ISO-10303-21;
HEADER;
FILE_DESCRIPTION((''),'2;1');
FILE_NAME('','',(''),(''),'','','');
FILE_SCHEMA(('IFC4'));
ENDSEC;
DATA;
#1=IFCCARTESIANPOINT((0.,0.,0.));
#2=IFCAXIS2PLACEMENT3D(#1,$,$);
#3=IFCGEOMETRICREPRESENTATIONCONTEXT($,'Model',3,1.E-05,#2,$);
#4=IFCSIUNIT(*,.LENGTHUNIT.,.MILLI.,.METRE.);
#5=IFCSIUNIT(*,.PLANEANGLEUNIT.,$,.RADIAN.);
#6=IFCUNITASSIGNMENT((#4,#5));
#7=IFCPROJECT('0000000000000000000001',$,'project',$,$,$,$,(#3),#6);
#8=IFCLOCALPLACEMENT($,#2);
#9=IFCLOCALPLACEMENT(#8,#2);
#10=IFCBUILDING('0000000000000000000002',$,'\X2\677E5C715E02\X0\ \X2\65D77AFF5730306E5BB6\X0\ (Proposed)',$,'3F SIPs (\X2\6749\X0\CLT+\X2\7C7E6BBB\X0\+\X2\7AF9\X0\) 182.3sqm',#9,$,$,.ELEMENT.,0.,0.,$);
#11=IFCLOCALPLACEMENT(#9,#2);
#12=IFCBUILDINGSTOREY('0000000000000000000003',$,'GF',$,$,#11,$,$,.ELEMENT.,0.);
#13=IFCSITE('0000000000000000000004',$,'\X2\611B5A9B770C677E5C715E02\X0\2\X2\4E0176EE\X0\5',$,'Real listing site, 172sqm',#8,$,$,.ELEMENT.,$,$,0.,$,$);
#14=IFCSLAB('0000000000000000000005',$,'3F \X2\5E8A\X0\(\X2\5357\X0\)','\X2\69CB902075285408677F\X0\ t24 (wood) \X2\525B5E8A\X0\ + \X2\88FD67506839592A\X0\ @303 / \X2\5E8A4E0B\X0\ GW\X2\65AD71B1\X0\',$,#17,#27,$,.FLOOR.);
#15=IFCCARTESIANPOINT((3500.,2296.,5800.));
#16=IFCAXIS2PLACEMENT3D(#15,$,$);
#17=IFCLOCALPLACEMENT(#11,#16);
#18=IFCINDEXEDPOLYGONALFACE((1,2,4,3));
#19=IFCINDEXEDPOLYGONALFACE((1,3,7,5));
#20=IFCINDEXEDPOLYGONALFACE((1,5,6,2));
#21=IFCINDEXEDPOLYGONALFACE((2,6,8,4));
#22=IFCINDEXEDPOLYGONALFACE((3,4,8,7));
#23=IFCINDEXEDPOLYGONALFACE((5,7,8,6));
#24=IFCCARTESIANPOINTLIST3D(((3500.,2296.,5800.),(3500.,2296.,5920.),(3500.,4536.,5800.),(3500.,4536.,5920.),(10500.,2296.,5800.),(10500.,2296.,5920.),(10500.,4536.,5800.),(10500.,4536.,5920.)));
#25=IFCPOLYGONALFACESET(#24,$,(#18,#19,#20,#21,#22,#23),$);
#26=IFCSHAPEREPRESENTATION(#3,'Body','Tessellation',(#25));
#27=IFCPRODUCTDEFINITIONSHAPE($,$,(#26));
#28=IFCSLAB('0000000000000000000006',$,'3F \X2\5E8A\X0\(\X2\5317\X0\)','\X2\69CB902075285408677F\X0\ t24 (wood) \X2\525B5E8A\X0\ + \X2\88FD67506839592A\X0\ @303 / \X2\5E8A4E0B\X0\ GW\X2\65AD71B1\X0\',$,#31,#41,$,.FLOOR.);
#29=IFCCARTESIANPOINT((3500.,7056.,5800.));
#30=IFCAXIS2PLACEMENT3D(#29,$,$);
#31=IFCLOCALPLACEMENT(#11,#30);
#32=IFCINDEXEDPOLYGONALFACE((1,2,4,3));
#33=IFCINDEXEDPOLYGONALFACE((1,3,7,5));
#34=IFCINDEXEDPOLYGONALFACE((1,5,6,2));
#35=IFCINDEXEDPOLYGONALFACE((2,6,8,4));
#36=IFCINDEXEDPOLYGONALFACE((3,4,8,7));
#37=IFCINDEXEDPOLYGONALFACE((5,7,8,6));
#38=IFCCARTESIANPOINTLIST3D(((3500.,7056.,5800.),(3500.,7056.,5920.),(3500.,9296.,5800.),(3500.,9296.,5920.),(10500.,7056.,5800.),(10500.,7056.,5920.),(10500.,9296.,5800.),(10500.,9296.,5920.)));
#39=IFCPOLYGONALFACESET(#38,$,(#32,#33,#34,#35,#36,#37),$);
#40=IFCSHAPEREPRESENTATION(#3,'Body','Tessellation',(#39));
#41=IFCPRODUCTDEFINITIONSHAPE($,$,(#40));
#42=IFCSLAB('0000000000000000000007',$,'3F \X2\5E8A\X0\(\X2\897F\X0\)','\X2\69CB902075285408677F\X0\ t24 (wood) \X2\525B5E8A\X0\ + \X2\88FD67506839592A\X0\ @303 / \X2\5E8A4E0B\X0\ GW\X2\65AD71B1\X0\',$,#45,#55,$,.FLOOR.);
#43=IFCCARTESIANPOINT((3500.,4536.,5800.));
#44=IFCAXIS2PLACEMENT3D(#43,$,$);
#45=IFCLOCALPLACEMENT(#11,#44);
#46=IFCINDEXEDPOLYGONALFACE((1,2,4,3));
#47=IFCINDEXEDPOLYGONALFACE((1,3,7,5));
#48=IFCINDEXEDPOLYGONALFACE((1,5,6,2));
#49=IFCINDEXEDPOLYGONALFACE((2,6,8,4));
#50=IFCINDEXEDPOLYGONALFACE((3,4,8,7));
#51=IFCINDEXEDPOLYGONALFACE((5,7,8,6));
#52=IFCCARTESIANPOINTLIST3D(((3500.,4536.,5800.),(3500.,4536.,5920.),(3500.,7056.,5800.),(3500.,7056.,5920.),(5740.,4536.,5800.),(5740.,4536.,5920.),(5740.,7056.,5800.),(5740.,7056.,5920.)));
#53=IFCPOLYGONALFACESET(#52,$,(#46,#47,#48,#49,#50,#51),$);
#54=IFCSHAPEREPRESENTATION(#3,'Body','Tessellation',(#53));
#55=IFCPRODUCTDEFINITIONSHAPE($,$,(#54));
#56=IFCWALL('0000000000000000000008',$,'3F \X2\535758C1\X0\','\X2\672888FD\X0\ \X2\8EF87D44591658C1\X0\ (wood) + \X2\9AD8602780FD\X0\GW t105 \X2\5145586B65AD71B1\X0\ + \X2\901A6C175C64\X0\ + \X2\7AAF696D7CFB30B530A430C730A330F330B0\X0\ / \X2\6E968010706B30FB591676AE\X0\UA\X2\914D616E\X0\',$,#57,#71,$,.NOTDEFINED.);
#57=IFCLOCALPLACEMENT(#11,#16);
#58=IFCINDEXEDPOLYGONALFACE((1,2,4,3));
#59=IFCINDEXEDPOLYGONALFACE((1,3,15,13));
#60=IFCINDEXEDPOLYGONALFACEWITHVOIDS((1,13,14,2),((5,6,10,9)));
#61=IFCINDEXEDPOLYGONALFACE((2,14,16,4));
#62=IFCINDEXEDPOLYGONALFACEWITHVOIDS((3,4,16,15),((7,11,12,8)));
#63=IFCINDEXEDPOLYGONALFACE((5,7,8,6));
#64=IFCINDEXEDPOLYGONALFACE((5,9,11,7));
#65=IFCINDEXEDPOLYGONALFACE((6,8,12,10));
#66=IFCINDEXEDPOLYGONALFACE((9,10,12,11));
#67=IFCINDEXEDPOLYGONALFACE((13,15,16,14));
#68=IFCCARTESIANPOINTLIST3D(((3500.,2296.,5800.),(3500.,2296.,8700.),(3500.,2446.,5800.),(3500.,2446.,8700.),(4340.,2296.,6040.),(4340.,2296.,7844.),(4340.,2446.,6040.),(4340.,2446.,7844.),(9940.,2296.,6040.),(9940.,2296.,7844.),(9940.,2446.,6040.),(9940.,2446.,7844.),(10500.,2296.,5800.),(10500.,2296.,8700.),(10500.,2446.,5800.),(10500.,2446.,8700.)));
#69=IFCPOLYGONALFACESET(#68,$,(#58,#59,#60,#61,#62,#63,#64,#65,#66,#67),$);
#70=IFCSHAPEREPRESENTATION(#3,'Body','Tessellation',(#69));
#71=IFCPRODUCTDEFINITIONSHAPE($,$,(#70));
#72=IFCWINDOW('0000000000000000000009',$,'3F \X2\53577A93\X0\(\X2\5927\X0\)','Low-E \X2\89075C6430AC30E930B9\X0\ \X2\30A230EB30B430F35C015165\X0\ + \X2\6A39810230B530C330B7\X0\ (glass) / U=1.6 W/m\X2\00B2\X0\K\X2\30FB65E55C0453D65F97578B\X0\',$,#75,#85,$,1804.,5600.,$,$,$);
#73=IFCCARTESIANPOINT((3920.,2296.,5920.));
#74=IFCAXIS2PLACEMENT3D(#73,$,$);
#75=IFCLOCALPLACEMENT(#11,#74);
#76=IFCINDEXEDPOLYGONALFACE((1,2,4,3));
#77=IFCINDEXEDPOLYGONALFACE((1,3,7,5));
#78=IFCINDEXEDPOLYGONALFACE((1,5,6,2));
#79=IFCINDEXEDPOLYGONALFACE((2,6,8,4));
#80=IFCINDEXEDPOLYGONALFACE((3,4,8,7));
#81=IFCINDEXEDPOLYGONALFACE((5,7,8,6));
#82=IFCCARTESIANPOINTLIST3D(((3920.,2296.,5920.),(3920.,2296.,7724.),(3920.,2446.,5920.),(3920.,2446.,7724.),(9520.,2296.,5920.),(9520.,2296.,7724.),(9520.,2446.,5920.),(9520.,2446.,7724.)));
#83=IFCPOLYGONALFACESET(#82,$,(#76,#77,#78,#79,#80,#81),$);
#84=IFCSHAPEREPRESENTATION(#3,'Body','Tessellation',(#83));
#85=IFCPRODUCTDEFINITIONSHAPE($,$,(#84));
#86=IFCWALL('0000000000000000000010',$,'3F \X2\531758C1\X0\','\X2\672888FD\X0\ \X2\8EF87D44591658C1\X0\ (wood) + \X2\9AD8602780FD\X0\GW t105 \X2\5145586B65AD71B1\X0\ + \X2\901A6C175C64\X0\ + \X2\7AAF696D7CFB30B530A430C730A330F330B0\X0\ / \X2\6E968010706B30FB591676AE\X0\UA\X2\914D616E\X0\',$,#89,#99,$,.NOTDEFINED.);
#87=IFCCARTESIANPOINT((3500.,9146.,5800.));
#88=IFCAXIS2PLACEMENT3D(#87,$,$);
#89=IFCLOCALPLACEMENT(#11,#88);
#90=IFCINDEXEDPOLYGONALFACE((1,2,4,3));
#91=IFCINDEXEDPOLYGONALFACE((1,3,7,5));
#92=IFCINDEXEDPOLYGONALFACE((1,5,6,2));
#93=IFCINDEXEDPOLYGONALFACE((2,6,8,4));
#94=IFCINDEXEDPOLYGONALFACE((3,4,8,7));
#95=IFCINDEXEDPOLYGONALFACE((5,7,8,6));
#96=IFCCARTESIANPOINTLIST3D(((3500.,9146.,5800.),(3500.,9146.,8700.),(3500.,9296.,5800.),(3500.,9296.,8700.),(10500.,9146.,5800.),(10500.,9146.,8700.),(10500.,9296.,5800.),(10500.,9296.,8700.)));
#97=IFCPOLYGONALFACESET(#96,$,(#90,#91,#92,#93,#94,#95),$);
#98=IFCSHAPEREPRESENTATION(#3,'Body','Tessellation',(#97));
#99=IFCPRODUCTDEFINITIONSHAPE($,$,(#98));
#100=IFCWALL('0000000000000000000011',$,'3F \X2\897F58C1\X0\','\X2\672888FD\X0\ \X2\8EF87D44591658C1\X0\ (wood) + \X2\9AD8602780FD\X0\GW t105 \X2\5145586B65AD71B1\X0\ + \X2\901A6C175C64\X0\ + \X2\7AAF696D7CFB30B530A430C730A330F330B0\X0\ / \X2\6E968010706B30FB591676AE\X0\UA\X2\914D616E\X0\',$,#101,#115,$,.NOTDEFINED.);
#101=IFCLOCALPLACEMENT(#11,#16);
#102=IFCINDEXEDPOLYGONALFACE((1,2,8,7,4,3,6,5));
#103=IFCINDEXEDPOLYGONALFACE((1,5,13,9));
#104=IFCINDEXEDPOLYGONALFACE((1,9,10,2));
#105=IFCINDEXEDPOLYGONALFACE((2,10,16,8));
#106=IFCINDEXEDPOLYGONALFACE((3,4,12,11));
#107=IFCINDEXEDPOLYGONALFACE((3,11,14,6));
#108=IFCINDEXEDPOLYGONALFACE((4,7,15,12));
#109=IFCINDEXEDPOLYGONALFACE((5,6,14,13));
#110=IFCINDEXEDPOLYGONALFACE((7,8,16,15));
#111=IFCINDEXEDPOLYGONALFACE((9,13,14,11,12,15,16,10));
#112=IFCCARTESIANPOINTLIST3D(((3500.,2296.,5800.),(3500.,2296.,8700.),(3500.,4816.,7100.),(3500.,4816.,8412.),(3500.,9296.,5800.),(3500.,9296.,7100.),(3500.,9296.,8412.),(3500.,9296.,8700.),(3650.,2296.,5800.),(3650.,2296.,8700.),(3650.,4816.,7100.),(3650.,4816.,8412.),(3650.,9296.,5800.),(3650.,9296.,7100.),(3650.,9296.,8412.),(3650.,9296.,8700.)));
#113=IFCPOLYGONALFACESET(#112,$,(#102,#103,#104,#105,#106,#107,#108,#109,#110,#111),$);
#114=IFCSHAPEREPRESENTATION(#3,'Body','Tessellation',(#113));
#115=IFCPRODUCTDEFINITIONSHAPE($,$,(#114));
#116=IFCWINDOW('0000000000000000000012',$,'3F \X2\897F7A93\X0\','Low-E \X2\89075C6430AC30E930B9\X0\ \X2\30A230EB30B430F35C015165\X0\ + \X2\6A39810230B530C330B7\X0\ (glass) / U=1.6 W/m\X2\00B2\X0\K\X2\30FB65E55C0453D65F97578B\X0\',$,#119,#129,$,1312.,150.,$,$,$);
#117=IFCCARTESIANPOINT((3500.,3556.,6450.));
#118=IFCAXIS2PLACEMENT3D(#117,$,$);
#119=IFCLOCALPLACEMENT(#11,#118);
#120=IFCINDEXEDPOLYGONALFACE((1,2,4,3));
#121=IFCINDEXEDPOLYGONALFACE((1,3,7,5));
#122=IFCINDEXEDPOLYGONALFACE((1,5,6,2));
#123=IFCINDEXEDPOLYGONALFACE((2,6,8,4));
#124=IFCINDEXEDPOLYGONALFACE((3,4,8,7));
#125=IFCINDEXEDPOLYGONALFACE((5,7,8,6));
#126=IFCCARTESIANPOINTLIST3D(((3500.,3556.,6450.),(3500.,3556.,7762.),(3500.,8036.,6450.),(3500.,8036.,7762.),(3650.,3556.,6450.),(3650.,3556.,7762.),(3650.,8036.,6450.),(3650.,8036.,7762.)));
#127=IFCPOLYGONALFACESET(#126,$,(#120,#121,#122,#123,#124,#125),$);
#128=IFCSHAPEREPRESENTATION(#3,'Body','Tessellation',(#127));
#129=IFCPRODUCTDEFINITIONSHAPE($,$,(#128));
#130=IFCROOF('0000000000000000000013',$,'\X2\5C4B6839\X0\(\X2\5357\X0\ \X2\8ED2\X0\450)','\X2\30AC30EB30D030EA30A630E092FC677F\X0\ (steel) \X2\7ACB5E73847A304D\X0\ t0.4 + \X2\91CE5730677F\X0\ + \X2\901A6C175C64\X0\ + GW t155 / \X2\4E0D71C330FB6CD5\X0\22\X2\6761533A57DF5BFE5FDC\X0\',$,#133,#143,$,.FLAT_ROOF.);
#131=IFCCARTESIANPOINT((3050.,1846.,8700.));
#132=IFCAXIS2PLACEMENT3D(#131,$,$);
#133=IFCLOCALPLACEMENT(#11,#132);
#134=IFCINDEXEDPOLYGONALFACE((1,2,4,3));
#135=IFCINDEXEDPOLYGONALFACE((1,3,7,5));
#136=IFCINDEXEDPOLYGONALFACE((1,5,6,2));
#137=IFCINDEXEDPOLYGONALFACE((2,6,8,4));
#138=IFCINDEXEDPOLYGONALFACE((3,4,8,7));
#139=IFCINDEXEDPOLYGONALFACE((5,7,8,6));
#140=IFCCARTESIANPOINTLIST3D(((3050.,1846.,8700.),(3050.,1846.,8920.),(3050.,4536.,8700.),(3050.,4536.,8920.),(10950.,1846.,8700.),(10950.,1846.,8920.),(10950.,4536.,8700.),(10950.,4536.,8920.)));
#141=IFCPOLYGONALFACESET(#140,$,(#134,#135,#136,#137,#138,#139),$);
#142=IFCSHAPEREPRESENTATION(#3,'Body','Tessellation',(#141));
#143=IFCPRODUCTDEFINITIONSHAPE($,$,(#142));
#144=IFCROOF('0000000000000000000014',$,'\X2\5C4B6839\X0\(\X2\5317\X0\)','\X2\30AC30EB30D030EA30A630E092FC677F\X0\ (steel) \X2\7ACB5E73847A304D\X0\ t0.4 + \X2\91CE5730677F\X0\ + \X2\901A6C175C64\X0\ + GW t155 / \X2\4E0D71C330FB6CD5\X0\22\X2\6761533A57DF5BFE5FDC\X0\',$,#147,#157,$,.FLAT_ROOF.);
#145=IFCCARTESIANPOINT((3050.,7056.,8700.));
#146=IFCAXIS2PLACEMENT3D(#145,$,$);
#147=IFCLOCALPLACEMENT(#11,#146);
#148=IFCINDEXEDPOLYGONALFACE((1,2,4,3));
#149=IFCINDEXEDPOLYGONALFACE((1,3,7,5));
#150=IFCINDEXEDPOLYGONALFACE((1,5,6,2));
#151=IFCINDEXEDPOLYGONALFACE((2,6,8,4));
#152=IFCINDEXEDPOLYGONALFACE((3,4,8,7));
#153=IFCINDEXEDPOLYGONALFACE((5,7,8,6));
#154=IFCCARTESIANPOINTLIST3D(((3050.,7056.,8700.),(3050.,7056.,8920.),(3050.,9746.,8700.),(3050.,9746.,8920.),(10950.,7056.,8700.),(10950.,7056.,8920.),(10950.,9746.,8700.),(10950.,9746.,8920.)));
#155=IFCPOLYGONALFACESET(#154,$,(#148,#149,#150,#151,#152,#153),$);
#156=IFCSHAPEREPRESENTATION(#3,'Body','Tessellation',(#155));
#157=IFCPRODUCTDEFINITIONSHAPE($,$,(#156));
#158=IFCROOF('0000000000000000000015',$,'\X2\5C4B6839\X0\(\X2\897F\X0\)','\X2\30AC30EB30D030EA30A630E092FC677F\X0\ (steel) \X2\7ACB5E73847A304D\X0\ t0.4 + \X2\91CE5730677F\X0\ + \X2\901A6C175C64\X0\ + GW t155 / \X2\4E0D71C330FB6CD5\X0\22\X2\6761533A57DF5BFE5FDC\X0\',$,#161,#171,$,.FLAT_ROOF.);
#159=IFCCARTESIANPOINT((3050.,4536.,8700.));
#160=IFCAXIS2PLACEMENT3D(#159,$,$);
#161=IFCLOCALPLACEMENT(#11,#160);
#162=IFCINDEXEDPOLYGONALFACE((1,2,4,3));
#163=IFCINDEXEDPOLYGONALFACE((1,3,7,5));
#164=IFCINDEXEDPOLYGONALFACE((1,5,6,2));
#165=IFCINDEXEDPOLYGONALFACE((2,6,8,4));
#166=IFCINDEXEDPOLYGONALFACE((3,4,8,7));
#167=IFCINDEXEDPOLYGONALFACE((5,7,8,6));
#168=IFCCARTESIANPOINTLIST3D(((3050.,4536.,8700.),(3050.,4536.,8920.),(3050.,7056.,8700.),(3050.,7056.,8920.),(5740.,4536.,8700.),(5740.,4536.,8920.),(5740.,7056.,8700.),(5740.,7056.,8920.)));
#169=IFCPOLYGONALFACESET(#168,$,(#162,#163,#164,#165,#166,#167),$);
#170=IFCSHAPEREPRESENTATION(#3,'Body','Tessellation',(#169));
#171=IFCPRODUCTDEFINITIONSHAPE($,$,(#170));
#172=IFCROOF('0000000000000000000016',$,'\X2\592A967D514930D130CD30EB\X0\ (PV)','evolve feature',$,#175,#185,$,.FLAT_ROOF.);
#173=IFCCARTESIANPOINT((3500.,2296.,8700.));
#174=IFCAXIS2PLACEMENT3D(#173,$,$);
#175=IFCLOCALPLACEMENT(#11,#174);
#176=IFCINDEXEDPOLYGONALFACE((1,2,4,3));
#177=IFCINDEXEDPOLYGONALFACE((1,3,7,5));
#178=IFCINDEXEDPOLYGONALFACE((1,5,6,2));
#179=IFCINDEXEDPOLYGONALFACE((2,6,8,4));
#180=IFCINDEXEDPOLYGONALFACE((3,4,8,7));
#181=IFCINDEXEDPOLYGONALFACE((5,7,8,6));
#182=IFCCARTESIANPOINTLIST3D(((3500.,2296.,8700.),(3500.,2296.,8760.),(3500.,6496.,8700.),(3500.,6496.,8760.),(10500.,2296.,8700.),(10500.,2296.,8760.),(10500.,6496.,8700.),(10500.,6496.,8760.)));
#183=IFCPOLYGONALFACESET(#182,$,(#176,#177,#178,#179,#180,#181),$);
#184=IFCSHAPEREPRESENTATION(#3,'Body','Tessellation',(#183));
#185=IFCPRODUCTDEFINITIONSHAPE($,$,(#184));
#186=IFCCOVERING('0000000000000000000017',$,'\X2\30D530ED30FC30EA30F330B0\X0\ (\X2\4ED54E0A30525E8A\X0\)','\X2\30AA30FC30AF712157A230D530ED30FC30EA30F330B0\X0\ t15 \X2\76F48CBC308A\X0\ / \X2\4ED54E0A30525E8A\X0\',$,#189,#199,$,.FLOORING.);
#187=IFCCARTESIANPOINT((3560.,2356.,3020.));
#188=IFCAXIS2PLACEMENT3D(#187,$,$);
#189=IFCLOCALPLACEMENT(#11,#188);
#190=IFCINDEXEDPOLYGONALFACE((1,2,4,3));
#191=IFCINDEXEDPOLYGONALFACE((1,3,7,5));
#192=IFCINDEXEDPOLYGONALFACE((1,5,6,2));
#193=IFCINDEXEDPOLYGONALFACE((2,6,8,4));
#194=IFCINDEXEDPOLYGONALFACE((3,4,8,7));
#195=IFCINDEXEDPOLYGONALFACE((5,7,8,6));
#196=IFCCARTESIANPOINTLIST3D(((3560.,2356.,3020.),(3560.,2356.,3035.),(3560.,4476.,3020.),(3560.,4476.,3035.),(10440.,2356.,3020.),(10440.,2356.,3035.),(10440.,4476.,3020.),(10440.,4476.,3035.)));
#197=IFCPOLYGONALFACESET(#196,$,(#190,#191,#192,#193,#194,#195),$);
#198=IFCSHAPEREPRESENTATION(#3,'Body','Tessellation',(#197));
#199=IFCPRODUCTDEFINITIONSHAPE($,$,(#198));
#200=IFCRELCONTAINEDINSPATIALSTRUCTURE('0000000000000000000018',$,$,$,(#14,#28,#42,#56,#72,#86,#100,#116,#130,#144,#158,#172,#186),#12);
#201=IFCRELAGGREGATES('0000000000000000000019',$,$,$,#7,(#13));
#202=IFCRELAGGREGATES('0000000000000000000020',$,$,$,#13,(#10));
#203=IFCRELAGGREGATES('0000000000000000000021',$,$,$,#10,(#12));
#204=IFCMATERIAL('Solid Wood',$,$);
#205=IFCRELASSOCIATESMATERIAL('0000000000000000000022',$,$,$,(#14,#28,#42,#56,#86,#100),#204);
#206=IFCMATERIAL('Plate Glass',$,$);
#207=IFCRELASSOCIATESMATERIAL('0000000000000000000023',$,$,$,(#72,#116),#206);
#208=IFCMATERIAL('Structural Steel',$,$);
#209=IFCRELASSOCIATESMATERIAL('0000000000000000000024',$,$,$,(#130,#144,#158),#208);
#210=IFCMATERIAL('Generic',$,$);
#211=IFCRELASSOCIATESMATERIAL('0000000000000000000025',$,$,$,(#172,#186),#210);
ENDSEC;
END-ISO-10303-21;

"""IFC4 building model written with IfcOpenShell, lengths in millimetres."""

from ifc_helpers import new_model, si_unit, frame, frame_2d, origin, place, context, project, spatial, rectangle, extrude, material, element, fill, save


model = new_model("IFC4")

# Units and contexts
model_context = context("Model", 3, precision=1e-05, world=origin())
ifc_project = project(units=[si_unit("LENGTHUNIT", "METRE", prefix="MILLI"), si_unit("PLANEANGLEUNIT", "RADIAN")], contexts=[model_context])

# Site, building, storey
site_placement = place(None, origin())
site = spatial("IfcSite", under=ifc_project, at=site_placement, Name="愛媛県松山市2丁目5", ObjectType="Real listing site, 172sqm", CompositionType="ELEMENT", RefElevation=0.0)
building_placement = place(site_placement, origin())
building = spatial("IfcBuilding", under=site, at=building_placement, Name="松山市 旗竿地の家 (Proposed)", ObjectType="3F SIPs (杉CLT+籾殻+竹) 182.3sqm", CompositionType="ELEMENT", ElevationOfRefHeight=0.0, ElevationOfTerrain=0.0)
storey_placement = place(building_placement, origin())
storey = spatial("IfcBuildingStorey", under=building, at=storey_placement, Name="GF", CompositionType="ELEMENT", Elevation=0.0)

# Slabs
ifc_material_1 = material(Name="Solid Wood")
slab_1_placement = place(storey_placement, frame((3500.0, 2296.0, 5800.0)))
element("IfcSlab", 1, at=slab_1_placement, inside=storey, material=ifc_material_1, Name="3F 床(南)", Description="構造用合板 t24 (wood) 剛床 + 製材根太 @303 / 床下 GW断熱", PredefinedType="FLOOR", context=model_context, shape_type="SweptSolid", body=[
    extrude(rectangle(XDim=7000.0, YDim=2240.0, at=frame_2d((3500.0, 1120.0))), frame((3500.0, 2296.0, 5800.0)), (0.0, 0.0, 1.0), 120.0),
])
slab_2_placement = place(storey_placement, frame((3500.0, 7056.0, 5800.0)))
element("IfcSlab", 2, at=slab_2_placement, inside=storey, material=ifc_material_1, Name="3F 床(北)", Description="構造用合板 t24 (wood) 剛床 + 製材根太 @303 / 床下 GW断熱", PredefinedType="FLOOR", context=model_context, shape_type="SweptSolid", body=[
    extrude(rectangle(XDim=7000.0, YDim=2240.0, at=frame_2d((3500.0, 1120.0))), frame((3500.0, 7056.0, 5800.0)), (0.0, 0.0, 1.0), 120.0),
])
slab_3_placement = place(storey_placement, frame((3500.0, 4536.0, 5800.0)))
element("IfcSlab", 3, at=slab_3_placement, inside=storey, material=ifc_material_1, Name="3F 床(西)", Description="構造用合板 t24 (wood) 剛床 + 製材根太 @303 / 床下 GW断熱", PredefinedType="FLOOR", context=model_context, shape_type="SweptSolid", body=[
    extrude(rectangle(XDim=2240.0, YDim=2520.0, at=frame_2d((1120.0, 1260.0))), frame((3500.0, 4536.0, 5800.0)), (0.0, 0.0, 1.0), 120.0),
])

# Wall, opening, window
wall_1_placement = place(storey_placement, frame((3500.0, 2296.0, 5800.0)))
wall_1 = element("IfcWall", 4, at=wall_1_placement, inside=storey, material=ifc_material_1, Name="3F 南壁", Description="木製 軸組外壁 (wood) + 高性能GW t105 充填断熱 + 通気層 + 窯業系サイディング / 準耐火・外皮UA配慮", PredefinedType="NOTDEFINED", context=model_context, shape_type="SweptSolid", body=[
    extrude(rectangle(XDim=7000.0, YDim=150.0, at=frame_2d((3500.0, 75.0))), frame((3500.0, 2296.0, 5800.0)), (0.0, 0.0, 1.0), 2900.0),
])
opening_1_placement = place(storey_placement, frame((3920.0, 2296.0, 5920.0)))
opening_1 = element("IfcOpeningElement", 5, at=opening_1_placement, cuts=wall_1, PredefinedType="NOTDEFINED", context=model_context, shape_type="SweptSolid", body=[
    extrude(rectangle(XDim=5600.0, YDim=150.0, at=frame_2d((2800.0, 75.0))), frame((3920.0, 2296.0, 5920.0)), (0.0, 0.0, 1.0), 1804.0),
])
ifc_material_2 = material(Name="Plate Glass")
window_1_placement = place(storey_placement, frame((3920.0, 2296.0, 5920.0)))
window_1 = element("IfcWindow", 6, at=window_1_placement, inside=storey, material=ifc_material_2, Name="3F 南窓(大)", Description="Low-E 複層ガラス アルゴン封入 + 樹脂サッシ (glass) / U=1.6 W/m²K・日射取得型", OverallHeight=1804.0, OverallWidth=5600.0, context=model_context, shape_type="SweptSolid", body=[
    extrude(rectangle(XDim=5600.0, YDim=150.0, at=frame_2d((2800.0, 75.0))), frame((3920.0, 2296.0, 5920.0)), (0.0, 0.0, 1.0), 1804.0),
])
fill(opening_1, window_1)

# Wall
wall_2_placement = place(storey_placement, frame((3500.0, 9146.0, 5800.0)))
element("IfcWall", 7, at=wall_2_placement, inside=storey, material=ifc_material_1, Name="3F 北壁", Description="木製 軸組外壁 (wood) + 高性能GW t105 充填断熱 + 通気層 + 窯業系サイディング / 準耐火・外皮UA配慮", PredefinedType="NOTDEFINED", context=model_context, shape_type="SweptSolid", body=[
    extrude(rectangle(XDim=7000.0, YDim=150.0, at=frame_2d((3500.0, 75.0))), frame((3500.0, 9146.0, 5800.0)), (0.0, 0.0, 1.0), 2900.0),
])

# Wall, opening, window
wall_3_placement = place(storey_placement, frame((3500.0, 2296.0, 5800.0)))
wall_3 = element("IfcWall", 8, at=wall_3_placement, inside=storey, material=ifc_material_1, Name="3F 西壁", Description="木製 軸組外壁 (wood) + 高性能GW t105 充填断熱 + 通気層 + 窯業系サイディング / 準耐火・外皮UA配慮", PredefinedType="NOTDEFINED", context=model_context, shape_type="SweptSolid", body=[
    extrude(rectangle(XDim=150.0, YDim=7000.0, at=frame_2d((75.0, 3500.0))), frame((3500.0, 2296.0, 5800.0)), (0.0, 0.0, 1.0), 2900.0),
])
opening_2_placement = place(storey_placement, frame((3500.0, 3556.0, 6450.0)))
opening_2 = element("IfcOpeningElement", 9, at=opening_2_placement, cuts=wall_3, PredefinedType="NOTDEFINED", context=model_context, shape_type="SweptSolid", body=[
    extrude(rectangle(XDim=150.0, YDim=4480.0, at=frame_2d((75.0, 2240.0))), frame((3500.0, 3556.0, 6450.0)), (0.0, 0.0, 1.0), 1312.0),
])
window_2_placement = place(storey_placement, frame((3500.0, 3556.0, 6450.0)))
window_2 = element("IfcWindow", 10, at=window_2_placement, inside=storey, material=ifc_material_2, Name="3F 西窓", Description="Low-E 複層ガラス アルゴン封入 + 樹脂サッシ (glass) / U=1.6 W/m²K・日射取得型", OverallHeight=1312.0, OverallWidth=150.0, context=model_context, shape_type="SweptSolid", body=[
    extrude(rectangle(XDim=150.0, YDim=4480.0, at=frame_2d((75.0, 2240.0))), frame((3500.0, 3556.0, 6450.0)), (0.0, 0.0, 1.0), 1312.0),
])
fill(opening_2, window_2)

# Roofs
ifc_material_3 = material(Name="Structural Steel")
roof_1_placement = place(storey_placement, frame((3050.0, 1846.0, 8700.0)))
element("IfcRoof", 11, at=roof_1_placement, inside=storey, material=ifc_material_3, Name="屋根(南 軒450)", Description="ガルバリウム鋼板 (steel) 立平葺き t0.4 + 野地板 + 通気層 + GW t155 / 不燃・法22条区域対応", PredefinedType="FLAT_ROOF", context=model_context, shape_type="SweptSolid", body=[
    extrude(rectangle(XDim=7900.0, YDim=2690.0, at=frame_2d((3950.0, 1345.0))), frame((3050.0, 1846.0, 8700.0)), (0.0, 0.0, 1.0), 220.0),
])
roof_2_placement = place(storey_placement, frame((3050.0, 7056.0, 8700.0)))
element("IfcRoof", 12, at=roof_2_placement, inside=storey, material=ifc_material_3, Name="屋根(北)", Description="ガルバリウム鋼板 (steel) 立平葺き t0.4 + 野地板 + 通気層 + GW t155 / 不燃・法22条区域対応", PredefinedType="FLAT_ROOF", context=model_context, shape_type="SweptSolid", body=[
    extrude(rectangle(XDim=7900.0, YDim=2690.0, at=frame_2d((3950.0, 1345.0))), frame((3050.0, 7056.0, 8700.0)), (0.0, 0.0, 1.0), 220.0),
])
roof_3_placement = place(storey_placement, frame((3050.0, 4536.0, 8700.0)))
element("IfcRoof", 13, at=roof_3_placement, inside=storey, material=ifc_material_3, Name="屋根(西)", Description="ガルバリウム鋼板 (steel) 立平葺き t0.4 + 野地板 + 通気層 + GW t155 / 不燃・法22条区域対応", PredefinedType="FLAT_ROOF", context=model_context, shape_type="SweptSolid", body=[
    extrude(rectangle(XDim=2690.0, YDim=2520.0, at=frame_2d((1345.0, 1260.0))), frame((3050.0, 4536.0, 8700.0)), (0.0, 0.0, 1.0), 220.0),
])
ifc_material_4 = material(Name="Generic")
roof_4_placement = place(storey_placement, frame((3500.0, 2296.0, 8700.0)))
element("IfcRoof", 14, at=roof_4_placement, inside=storey, material=ifc_material_4, Name="太陽光パネル (PV)", Description="evolve feature", PredefinedType="FLAT_ROOF", context=model_context, shape_type="SweptSolid", body=[
    extrude(rectangle(XDim=7000.0, YDim=4200.0, at=frame_2d((3500.0, 2100.0))), frame((3500.0, 2296.0, 8700.0)), (0.0, 0.0, 1.0), 60.0),
])

# Covering
covering_1_placement = place(storey_placement, frame((3560.0, 2356.0, 3020.0)))
element("IfcCovering", 15, at=covering_1_placement, inside=storey, material=ifc_material_4, Name="フローリング (仕上げ床)", Description="オーク無垢フローリング t15 直貼り / 仕上げ床", PredefinedType="FLOORING", context=model_context, shape_type="SweptSolid", body=[
    extrude(rectangle(XDim=6880.0, YDim=2120.0, at=frame_2d((3440.0, 1060.0))), frame((3560.0, 2356.0, 3020.0)), (0.0, 0.0, 1.0), 15.0),
])

save(model, "model.ifc")
